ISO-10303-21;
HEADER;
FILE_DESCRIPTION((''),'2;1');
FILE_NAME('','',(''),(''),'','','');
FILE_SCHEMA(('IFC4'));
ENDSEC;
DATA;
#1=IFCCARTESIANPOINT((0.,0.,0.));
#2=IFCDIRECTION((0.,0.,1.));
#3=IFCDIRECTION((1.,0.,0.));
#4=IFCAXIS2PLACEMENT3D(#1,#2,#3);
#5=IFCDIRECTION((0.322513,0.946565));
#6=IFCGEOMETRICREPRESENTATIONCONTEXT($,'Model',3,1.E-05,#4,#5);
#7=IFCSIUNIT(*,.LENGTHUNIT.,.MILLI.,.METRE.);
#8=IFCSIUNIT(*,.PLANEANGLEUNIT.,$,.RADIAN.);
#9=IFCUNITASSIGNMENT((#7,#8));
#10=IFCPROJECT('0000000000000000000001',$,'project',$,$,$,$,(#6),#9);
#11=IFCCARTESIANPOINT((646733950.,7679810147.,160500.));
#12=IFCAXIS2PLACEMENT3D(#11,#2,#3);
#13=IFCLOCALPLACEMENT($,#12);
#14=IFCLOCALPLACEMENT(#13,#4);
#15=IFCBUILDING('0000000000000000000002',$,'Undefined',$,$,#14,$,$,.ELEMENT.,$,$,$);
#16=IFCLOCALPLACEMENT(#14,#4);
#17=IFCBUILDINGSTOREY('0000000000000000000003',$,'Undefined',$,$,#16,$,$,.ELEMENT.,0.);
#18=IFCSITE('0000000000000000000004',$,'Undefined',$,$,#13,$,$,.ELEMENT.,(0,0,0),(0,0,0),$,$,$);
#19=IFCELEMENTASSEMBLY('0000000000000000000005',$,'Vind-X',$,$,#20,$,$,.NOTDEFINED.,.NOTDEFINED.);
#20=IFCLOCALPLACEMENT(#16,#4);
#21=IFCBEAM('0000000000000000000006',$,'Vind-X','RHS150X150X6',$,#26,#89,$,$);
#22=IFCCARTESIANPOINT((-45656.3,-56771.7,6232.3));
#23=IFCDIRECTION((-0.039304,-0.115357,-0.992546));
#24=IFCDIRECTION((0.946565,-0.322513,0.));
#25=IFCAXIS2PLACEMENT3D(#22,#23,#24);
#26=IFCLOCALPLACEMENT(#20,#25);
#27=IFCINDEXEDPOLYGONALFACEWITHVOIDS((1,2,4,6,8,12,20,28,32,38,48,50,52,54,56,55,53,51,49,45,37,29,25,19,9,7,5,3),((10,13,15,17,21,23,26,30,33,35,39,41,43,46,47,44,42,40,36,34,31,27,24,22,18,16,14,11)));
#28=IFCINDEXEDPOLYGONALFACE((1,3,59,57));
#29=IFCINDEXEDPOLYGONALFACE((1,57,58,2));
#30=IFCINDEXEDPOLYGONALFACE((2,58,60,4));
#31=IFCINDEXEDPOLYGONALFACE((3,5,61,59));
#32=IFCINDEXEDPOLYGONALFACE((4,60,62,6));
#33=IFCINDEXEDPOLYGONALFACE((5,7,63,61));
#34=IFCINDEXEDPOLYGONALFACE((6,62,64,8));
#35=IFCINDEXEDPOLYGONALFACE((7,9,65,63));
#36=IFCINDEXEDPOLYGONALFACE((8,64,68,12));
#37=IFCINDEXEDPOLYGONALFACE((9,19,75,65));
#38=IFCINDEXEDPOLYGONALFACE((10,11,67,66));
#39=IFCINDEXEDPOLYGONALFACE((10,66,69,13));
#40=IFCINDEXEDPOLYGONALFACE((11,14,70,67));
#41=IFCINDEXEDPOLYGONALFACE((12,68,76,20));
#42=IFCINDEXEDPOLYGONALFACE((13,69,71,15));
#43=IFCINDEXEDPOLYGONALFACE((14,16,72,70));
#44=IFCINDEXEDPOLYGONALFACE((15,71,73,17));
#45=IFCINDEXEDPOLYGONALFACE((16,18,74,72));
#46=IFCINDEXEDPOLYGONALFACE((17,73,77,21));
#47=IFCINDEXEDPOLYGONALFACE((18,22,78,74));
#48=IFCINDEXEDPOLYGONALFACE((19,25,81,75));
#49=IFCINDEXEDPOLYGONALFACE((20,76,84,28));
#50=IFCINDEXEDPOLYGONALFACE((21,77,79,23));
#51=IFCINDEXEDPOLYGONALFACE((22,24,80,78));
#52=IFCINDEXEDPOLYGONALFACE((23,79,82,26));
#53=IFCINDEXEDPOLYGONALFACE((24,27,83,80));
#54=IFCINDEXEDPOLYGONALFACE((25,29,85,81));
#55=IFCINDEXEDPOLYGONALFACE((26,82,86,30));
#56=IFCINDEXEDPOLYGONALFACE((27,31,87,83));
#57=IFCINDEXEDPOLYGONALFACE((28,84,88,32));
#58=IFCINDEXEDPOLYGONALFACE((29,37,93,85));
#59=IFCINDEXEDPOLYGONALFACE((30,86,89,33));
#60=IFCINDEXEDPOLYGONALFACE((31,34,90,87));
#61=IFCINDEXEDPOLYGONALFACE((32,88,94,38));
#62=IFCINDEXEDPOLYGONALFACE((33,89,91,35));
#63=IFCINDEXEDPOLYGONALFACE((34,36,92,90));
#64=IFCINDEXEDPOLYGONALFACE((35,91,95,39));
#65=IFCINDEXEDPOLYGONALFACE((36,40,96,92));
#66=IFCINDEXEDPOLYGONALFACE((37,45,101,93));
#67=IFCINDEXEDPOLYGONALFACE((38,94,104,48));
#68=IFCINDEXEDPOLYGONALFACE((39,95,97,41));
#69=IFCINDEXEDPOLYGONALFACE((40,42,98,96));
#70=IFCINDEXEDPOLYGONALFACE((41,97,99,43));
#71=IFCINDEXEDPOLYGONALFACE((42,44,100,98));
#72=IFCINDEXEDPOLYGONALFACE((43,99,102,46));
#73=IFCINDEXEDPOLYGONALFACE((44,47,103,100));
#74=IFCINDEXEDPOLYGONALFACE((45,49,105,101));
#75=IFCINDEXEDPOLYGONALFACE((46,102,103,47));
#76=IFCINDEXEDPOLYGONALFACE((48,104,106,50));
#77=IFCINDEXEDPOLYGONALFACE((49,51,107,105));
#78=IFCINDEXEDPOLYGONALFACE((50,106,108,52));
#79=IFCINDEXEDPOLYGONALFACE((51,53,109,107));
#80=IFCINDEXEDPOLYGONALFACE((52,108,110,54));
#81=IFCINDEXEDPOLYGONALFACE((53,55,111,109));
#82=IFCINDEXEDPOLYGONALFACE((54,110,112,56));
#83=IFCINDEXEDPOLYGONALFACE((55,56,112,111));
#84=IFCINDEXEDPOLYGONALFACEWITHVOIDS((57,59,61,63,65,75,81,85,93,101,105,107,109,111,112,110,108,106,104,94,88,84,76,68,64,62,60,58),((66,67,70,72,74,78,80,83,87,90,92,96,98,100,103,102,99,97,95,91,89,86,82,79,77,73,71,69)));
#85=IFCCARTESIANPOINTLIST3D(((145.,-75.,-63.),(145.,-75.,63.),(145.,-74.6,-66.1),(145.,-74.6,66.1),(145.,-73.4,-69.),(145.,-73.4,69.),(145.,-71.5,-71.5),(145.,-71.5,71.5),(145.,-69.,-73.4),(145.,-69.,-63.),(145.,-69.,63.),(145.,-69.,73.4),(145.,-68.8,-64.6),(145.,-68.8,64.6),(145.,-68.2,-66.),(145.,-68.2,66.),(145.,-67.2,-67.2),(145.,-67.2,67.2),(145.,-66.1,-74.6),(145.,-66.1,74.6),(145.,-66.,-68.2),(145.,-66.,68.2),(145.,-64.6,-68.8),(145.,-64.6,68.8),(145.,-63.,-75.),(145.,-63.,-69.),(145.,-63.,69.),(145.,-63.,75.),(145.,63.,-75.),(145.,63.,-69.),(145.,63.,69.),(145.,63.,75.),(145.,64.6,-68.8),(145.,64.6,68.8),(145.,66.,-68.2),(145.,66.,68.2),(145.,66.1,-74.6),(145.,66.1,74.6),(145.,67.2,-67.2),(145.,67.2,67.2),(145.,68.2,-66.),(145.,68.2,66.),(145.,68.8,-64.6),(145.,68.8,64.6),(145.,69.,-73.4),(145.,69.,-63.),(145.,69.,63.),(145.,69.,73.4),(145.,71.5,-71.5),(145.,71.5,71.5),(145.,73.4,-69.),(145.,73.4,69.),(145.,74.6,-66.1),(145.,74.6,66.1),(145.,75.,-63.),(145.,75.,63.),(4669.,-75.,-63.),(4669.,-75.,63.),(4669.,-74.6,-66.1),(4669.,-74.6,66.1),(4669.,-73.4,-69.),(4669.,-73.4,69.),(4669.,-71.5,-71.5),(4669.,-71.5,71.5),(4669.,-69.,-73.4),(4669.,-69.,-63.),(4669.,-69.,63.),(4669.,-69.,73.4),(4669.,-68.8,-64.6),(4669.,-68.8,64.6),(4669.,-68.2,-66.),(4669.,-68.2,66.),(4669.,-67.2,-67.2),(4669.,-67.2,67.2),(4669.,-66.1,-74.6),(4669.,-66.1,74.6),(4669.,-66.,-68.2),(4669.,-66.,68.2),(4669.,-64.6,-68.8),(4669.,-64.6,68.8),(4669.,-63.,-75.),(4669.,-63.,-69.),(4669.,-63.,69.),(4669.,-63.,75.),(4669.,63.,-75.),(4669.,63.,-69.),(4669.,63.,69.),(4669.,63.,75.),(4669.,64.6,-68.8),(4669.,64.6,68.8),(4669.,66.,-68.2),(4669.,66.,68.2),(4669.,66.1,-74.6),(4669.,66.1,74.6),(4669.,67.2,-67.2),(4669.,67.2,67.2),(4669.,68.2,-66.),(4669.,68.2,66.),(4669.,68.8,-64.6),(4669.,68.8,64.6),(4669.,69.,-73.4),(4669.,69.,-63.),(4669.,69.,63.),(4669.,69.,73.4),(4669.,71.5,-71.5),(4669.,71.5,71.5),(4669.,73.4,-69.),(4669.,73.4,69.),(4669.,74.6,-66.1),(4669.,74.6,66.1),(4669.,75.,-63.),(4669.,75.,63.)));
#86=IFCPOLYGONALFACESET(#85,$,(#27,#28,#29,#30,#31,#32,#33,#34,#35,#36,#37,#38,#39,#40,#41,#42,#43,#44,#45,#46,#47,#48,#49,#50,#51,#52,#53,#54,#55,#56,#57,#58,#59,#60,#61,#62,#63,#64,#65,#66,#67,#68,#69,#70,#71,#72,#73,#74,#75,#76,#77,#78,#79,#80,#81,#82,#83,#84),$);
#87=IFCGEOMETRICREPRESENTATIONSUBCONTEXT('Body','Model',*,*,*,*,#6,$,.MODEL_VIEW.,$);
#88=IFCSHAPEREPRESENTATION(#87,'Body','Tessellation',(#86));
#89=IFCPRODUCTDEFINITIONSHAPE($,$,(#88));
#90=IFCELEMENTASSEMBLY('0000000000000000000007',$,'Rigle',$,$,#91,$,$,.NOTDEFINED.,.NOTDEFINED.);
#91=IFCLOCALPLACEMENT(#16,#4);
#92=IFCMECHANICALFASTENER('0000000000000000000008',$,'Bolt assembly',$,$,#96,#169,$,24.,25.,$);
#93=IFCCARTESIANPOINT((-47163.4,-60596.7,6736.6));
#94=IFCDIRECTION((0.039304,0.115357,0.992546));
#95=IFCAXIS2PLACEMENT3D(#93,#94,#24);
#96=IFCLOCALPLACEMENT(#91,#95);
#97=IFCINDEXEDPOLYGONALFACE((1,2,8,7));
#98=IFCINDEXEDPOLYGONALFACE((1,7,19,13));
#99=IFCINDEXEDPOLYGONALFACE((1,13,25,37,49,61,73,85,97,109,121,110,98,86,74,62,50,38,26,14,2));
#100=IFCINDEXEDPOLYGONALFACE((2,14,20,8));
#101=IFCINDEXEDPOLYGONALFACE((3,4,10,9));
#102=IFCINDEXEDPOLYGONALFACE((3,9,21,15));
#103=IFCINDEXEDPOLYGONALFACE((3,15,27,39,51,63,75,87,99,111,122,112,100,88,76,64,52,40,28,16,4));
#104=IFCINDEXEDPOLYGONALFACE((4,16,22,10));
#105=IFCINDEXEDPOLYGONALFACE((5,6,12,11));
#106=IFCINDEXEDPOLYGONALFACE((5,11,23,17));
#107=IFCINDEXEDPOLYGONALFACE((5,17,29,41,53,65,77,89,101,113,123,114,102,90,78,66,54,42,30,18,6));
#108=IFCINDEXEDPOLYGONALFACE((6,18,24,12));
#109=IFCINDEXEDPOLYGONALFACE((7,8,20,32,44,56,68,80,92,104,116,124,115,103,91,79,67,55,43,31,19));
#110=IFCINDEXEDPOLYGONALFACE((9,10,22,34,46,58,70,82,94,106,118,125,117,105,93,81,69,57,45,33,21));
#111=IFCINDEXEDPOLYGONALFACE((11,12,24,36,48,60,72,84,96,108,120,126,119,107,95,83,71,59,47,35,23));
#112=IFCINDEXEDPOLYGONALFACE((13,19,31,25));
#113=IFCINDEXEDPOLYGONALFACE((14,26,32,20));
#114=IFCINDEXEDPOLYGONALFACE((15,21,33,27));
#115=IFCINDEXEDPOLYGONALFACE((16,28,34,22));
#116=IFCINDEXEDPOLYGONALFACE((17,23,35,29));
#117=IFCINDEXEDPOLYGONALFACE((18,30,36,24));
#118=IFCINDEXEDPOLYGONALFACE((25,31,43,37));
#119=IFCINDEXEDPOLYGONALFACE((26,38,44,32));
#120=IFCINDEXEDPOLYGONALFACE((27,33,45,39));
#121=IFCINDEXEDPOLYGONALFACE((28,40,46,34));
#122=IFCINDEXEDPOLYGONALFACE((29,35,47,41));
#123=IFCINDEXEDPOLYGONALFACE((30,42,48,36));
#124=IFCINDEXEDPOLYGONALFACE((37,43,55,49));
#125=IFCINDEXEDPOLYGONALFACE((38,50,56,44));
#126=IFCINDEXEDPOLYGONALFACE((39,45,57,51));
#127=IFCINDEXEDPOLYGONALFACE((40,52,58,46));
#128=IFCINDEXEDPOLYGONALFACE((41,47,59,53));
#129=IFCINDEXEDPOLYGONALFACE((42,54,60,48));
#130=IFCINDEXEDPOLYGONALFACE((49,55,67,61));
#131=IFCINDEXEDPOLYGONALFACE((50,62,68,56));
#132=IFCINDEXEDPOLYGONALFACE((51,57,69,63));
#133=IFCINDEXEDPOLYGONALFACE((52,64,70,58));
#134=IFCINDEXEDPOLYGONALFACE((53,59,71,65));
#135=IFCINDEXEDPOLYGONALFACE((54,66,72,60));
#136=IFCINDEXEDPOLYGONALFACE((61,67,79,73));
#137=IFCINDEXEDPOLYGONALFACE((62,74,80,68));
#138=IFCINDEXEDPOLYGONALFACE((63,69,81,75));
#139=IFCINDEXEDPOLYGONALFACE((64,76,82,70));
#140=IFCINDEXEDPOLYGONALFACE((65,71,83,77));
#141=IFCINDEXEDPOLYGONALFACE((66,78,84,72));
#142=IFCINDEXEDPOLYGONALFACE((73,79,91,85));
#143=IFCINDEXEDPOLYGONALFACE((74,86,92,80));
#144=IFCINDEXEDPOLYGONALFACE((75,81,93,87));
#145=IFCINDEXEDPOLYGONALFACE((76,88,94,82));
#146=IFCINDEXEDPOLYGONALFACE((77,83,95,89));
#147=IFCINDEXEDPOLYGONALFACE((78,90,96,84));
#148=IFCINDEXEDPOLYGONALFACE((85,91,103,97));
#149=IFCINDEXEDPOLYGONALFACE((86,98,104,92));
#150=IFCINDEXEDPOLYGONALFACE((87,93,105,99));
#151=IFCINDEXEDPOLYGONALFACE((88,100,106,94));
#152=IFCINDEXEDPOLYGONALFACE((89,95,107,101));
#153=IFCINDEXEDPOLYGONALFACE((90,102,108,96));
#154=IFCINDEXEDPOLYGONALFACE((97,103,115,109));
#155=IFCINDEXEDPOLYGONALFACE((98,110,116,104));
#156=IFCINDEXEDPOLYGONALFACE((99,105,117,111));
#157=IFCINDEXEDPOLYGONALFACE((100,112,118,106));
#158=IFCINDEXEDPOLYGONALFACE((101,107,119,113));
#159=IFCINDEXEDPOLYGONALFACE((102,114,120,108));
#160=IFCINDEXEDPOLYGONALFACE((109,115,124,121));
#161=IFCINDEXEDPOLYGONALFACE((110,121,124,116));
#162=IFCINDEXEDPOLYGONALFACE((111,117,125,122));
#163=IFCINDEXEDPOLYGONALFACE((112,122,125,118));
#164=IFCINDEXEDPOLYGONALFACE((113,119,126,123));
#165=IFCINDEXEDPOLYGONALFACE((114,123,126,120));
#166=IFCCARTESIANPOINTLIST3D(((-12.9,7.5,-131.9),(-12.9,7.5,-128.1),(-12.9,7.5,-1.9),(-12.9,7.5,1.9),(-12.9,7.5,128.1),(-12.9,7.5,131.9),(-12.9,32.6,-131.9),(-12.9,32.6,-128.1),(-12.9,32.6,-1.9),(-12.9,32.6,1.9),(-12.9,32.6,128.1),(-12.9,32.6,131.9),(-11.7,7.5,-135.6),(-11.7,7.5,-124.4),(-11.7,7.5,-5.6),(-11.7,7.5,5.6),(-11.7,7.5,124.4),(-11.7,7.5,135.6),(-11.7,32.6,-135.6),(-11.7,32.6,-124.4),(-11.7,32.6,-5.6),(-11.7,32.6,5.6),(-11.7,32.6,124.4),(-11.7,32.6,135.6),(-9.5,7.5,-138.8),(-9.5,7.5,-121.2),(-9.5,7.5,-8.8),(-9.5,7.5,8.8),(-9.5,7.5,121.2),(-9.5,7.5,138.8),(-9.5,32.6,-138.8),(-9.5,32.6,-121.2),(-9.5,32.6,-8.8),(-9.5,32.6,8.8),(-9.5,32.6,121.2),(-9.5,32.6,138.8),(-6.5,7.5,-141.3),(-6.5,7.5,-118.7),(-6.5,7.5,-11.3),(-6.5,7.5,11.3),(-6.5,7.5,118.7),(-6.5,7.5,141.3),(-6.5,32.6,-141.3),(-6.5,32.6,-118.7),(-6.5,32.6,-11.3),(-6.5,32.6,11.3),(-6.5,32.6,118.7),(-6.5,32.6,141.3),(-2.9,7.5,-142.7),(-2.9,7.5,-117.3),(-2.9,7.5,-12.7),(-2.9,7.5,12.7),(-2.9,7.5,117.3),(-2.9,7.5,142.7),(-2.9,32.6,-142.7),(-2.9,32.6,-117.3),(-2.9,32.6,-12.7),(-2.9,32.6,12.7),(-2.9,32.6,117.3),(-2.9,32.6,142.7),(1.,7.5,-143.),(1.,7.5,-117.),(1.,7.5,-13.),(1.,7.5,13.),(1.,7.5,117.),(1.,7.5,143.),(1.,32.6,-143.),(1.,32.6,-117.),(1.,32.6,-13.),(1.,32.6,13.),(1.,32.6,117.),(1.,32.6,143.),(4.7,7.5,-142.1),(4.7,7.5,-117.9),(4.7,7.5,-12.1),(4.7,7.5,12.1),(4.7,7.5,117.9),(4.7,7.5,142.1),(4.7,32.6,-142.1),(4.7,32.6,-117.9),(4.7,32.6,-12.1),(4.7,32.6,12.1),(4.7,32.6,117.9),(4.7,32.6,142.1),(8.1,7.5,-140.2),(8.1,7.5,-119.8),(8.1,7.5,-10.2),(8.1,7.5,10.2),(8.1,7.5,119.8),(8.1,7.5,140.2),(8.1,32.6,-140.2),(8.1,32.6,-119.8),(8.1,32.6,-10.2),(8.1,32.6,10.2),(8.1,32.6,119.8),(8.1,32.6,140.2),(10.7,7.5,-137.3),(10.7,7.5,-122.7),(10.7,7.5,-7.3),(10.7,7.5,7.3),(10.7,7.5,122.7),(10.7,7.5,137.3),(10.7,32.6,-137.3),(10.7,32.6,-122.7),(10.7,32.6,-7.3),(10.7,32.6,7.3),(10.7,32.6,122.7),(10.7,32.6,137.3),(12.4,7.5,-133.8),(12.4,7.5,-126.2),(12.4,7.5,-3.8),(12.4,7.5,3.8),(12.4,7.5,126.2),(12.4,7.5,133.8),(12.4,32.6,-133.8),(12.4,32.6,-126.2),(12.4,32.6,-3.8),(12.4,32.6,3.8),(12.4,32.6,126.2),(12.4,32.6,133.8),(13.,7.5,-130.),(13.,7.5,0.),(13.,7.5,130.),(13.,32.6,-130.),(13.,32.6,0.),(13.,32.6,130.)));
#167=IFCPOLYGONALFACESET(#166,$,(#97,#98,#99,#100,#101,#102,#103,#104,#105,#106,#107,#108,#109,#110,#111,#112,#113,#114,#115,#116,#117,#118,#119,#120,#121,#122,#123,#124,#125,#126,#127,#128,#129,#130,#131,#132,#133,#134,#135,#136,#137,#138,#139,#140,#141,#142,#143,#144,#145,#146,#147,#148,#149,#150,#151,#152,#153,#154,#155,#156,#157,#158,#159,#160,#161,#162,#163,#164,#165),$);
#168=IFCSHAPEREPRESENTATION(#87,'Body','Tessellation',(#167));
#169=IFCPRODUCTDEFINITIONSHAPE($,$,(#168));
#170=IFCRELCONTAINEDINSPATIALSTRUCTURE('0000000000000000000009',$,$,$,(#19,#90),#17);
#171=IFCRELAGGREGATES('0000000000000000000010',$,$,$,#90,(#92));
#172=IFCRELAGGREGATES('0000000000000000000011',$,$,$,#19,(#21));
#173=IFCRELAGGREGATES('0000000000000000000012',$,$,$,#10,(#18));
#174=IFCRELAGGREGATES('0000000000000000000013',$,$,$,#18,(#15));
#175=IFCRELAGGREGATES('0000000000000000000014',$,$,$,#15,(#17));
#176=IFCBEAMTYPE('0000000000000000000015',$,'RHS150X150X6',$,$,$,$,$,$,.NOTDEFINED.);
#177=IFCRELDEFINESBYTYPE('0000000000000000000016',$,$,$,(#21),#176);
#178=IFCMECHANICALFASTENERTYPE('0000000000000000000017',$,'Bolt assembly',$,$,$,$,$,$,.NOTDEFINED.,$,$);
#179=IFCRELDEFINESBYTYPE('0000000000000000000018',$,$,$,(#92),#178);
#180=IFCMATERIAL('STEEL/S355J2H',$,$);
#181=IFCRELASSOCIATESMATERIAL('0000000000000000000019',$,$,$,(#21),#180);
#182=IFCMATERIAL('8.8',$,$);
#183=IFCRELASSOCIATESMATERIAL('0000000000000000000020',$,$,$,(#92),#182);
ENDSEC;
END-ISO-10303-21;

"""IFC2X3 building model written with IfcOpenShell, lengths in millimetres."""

from ifc_helpers import new_model, si_unit, direction, frame, origin_with_axes, origin_2d_with_axis, place, context, subcontext, project, spatial, hollow_rectangle, circle, extrude, clip, halfspace, source, transform, mapped, material, type_object, element, aggregate, save


model = new_model("IFC2X3")

# Units and contexts
model_context = context("Model", 3, precision=1e-05, world=origin_with_axes(), true_north=direction((0.322513, 0.946565)))
body_context = subcontext(model_context, "Body", "Model", "MODEL_VIEW")
ifc_project = project(units=[si_unit("LENGTHUNIT", "METRE", prefix="MILLI"), si_unit("PLANEANGLEUNIT", "RADIAN")], contexts=[model_context])

# Site, building, storey
site_placement = place(None, frame((646733950.0, 7679810147.0, 160500.0), z_axis=(0.0, 0.0, 1.0), x_axis=(1.0, 0.0, 0.0)))
site = spatial("IfcSite", under=ifc_project, at=site_placement, Name="Undefined", CompositionType="ELEMENT", RefLatitude=(0, 0, 0), RefLongitude=(0, 0, 0))
building_placement = place(site_placement, origin_with_axes())
building = spatial("IfcBuilding", under=site, at=building_placement, Name="Undefined", CompositionType="ELEMENT")
storey_placement = place(building_placement, origin_with_axes())
storey = spatial("IfcBuildingStorey", under=building, at=storey_placement, Name="Undefined", CompositionType="ELEMENT", Elevation=0.0)

# Element assembly, beam
ifc_material_1 = material(Name="STEEL/S355J2H")
beam_type_1 = type_object("IfcBeamType", Name="RHS150X150X6", PredefinedType="NOTDEFINED")
assembly_1_placement = place(storey_placement, origin_with_axes())
assembly_1 = element("IfcElementAssembly", 1, at=assembly_1_placement, inside=storey, Name="Vind-X", AssemblyPlace="NOTDEFINED", PredefinedType="NOTDEFINED")
beam_1_placement = place(assembly_1_placement, frame((-45656.3, -56771.7, 6232.3), z_axis=(-0.039304, -0.115357, -0.992546), x_axis=(0.946565, -0.322513, 0.0)))
beam_1 = element("IfcBeam", 2, at=beam_1_placement, type_object=beam_type_1, material=ifc_material_1, Name="Vind-X", Description="RHS150X150X6", context=body_context, shape_type="Clipping", body=[
    clip(clip(extrude(hollow_rectangle(XDim=150.0, YDim=150.0, WallThickness=6.0, InnerFilletRadius=6.0, OuterFilletRadius=12.0, at=origin_2d_with_axis()), frame((4814.0, 0.0, 0.0), z_axis=(-1.0, 0.0, 0.0), x_axis=(0.0, -1.0, 0.0)), (0.0, 0.0, 1.0), 4814.0), halfspace(frame((4669.0, 0.0, 0.0), z_axis=(-1.0, 0.0, 0.0), x_axis=(0.0, 1.0, 0.0)), True)), halfspace(frame((145.0, 0.0, 0.0), z_axis=(1.0, 0.0, 0.0), x_axis=(0.0, -1.0, 0.0)), True)),
])

# Element assembly
assembly_2_placement = place(storey_placement, origin_with_axes())
assembly_2 = element("IfcElementAssembly", 3, at=assembly_2_placement, inside=storey, Name="Rigle", AssemblyPlace="NOTDEFINED", PredefinedType="NOTDEFINED")

# Shared definitions
ifc_material_2 = material(Name="8.8")
mechanical_fastener_type = type_object("IfcMechanicalFastenerType", Name="Bolt assembly")

# Mechanical fastener
shared_shape_1 = source(origin_with_axes(), body_context, "Body", "SweptSolid", [
    extrude(circle(Radius=13.0, at=origin_2d_with_axis()), frame((0.0, 7.5, 0.0), z_axis=(0.0, 1.0, 0.0), x_axis=(1.0, 0.0, 0.0)), (0.0, 0.0, 1.0), 25.1),
])
mechanical_fastener_1_placement = place(assembly_2_placement, frame((-47163.4, -60596.7, 6736.6), z_axis=(0.039304, 0.115357, 0.992546), x_axis=(0.946565, -0.322513, 0.0)))
mechanical_fastener_1 = element("IfcMechanicalFastener", 4, at=mechanical_fastener_1_placement, type_object=mechanical_fastener_type, material=ifc_material_2, Name="Bolt assembly", NominalDiameter=24.0, NominalLength=25.0, context=body_context, shape_type="MappedRepresentation", body=[
    mapped(shared_shape_1, transform((0.0, 0.0, -130.0))),
    mapped(shared_shape_1, transform((0.0, 0.0, 0.0))),
    mapped(shared_shape_1, transform((0.0, 0.0, 130.0))),
])
aggregate(assembly_2, [mechanical_fastener_1])
aggregate(assembly_1, [beam_1])

save(model, "model.ifc")
